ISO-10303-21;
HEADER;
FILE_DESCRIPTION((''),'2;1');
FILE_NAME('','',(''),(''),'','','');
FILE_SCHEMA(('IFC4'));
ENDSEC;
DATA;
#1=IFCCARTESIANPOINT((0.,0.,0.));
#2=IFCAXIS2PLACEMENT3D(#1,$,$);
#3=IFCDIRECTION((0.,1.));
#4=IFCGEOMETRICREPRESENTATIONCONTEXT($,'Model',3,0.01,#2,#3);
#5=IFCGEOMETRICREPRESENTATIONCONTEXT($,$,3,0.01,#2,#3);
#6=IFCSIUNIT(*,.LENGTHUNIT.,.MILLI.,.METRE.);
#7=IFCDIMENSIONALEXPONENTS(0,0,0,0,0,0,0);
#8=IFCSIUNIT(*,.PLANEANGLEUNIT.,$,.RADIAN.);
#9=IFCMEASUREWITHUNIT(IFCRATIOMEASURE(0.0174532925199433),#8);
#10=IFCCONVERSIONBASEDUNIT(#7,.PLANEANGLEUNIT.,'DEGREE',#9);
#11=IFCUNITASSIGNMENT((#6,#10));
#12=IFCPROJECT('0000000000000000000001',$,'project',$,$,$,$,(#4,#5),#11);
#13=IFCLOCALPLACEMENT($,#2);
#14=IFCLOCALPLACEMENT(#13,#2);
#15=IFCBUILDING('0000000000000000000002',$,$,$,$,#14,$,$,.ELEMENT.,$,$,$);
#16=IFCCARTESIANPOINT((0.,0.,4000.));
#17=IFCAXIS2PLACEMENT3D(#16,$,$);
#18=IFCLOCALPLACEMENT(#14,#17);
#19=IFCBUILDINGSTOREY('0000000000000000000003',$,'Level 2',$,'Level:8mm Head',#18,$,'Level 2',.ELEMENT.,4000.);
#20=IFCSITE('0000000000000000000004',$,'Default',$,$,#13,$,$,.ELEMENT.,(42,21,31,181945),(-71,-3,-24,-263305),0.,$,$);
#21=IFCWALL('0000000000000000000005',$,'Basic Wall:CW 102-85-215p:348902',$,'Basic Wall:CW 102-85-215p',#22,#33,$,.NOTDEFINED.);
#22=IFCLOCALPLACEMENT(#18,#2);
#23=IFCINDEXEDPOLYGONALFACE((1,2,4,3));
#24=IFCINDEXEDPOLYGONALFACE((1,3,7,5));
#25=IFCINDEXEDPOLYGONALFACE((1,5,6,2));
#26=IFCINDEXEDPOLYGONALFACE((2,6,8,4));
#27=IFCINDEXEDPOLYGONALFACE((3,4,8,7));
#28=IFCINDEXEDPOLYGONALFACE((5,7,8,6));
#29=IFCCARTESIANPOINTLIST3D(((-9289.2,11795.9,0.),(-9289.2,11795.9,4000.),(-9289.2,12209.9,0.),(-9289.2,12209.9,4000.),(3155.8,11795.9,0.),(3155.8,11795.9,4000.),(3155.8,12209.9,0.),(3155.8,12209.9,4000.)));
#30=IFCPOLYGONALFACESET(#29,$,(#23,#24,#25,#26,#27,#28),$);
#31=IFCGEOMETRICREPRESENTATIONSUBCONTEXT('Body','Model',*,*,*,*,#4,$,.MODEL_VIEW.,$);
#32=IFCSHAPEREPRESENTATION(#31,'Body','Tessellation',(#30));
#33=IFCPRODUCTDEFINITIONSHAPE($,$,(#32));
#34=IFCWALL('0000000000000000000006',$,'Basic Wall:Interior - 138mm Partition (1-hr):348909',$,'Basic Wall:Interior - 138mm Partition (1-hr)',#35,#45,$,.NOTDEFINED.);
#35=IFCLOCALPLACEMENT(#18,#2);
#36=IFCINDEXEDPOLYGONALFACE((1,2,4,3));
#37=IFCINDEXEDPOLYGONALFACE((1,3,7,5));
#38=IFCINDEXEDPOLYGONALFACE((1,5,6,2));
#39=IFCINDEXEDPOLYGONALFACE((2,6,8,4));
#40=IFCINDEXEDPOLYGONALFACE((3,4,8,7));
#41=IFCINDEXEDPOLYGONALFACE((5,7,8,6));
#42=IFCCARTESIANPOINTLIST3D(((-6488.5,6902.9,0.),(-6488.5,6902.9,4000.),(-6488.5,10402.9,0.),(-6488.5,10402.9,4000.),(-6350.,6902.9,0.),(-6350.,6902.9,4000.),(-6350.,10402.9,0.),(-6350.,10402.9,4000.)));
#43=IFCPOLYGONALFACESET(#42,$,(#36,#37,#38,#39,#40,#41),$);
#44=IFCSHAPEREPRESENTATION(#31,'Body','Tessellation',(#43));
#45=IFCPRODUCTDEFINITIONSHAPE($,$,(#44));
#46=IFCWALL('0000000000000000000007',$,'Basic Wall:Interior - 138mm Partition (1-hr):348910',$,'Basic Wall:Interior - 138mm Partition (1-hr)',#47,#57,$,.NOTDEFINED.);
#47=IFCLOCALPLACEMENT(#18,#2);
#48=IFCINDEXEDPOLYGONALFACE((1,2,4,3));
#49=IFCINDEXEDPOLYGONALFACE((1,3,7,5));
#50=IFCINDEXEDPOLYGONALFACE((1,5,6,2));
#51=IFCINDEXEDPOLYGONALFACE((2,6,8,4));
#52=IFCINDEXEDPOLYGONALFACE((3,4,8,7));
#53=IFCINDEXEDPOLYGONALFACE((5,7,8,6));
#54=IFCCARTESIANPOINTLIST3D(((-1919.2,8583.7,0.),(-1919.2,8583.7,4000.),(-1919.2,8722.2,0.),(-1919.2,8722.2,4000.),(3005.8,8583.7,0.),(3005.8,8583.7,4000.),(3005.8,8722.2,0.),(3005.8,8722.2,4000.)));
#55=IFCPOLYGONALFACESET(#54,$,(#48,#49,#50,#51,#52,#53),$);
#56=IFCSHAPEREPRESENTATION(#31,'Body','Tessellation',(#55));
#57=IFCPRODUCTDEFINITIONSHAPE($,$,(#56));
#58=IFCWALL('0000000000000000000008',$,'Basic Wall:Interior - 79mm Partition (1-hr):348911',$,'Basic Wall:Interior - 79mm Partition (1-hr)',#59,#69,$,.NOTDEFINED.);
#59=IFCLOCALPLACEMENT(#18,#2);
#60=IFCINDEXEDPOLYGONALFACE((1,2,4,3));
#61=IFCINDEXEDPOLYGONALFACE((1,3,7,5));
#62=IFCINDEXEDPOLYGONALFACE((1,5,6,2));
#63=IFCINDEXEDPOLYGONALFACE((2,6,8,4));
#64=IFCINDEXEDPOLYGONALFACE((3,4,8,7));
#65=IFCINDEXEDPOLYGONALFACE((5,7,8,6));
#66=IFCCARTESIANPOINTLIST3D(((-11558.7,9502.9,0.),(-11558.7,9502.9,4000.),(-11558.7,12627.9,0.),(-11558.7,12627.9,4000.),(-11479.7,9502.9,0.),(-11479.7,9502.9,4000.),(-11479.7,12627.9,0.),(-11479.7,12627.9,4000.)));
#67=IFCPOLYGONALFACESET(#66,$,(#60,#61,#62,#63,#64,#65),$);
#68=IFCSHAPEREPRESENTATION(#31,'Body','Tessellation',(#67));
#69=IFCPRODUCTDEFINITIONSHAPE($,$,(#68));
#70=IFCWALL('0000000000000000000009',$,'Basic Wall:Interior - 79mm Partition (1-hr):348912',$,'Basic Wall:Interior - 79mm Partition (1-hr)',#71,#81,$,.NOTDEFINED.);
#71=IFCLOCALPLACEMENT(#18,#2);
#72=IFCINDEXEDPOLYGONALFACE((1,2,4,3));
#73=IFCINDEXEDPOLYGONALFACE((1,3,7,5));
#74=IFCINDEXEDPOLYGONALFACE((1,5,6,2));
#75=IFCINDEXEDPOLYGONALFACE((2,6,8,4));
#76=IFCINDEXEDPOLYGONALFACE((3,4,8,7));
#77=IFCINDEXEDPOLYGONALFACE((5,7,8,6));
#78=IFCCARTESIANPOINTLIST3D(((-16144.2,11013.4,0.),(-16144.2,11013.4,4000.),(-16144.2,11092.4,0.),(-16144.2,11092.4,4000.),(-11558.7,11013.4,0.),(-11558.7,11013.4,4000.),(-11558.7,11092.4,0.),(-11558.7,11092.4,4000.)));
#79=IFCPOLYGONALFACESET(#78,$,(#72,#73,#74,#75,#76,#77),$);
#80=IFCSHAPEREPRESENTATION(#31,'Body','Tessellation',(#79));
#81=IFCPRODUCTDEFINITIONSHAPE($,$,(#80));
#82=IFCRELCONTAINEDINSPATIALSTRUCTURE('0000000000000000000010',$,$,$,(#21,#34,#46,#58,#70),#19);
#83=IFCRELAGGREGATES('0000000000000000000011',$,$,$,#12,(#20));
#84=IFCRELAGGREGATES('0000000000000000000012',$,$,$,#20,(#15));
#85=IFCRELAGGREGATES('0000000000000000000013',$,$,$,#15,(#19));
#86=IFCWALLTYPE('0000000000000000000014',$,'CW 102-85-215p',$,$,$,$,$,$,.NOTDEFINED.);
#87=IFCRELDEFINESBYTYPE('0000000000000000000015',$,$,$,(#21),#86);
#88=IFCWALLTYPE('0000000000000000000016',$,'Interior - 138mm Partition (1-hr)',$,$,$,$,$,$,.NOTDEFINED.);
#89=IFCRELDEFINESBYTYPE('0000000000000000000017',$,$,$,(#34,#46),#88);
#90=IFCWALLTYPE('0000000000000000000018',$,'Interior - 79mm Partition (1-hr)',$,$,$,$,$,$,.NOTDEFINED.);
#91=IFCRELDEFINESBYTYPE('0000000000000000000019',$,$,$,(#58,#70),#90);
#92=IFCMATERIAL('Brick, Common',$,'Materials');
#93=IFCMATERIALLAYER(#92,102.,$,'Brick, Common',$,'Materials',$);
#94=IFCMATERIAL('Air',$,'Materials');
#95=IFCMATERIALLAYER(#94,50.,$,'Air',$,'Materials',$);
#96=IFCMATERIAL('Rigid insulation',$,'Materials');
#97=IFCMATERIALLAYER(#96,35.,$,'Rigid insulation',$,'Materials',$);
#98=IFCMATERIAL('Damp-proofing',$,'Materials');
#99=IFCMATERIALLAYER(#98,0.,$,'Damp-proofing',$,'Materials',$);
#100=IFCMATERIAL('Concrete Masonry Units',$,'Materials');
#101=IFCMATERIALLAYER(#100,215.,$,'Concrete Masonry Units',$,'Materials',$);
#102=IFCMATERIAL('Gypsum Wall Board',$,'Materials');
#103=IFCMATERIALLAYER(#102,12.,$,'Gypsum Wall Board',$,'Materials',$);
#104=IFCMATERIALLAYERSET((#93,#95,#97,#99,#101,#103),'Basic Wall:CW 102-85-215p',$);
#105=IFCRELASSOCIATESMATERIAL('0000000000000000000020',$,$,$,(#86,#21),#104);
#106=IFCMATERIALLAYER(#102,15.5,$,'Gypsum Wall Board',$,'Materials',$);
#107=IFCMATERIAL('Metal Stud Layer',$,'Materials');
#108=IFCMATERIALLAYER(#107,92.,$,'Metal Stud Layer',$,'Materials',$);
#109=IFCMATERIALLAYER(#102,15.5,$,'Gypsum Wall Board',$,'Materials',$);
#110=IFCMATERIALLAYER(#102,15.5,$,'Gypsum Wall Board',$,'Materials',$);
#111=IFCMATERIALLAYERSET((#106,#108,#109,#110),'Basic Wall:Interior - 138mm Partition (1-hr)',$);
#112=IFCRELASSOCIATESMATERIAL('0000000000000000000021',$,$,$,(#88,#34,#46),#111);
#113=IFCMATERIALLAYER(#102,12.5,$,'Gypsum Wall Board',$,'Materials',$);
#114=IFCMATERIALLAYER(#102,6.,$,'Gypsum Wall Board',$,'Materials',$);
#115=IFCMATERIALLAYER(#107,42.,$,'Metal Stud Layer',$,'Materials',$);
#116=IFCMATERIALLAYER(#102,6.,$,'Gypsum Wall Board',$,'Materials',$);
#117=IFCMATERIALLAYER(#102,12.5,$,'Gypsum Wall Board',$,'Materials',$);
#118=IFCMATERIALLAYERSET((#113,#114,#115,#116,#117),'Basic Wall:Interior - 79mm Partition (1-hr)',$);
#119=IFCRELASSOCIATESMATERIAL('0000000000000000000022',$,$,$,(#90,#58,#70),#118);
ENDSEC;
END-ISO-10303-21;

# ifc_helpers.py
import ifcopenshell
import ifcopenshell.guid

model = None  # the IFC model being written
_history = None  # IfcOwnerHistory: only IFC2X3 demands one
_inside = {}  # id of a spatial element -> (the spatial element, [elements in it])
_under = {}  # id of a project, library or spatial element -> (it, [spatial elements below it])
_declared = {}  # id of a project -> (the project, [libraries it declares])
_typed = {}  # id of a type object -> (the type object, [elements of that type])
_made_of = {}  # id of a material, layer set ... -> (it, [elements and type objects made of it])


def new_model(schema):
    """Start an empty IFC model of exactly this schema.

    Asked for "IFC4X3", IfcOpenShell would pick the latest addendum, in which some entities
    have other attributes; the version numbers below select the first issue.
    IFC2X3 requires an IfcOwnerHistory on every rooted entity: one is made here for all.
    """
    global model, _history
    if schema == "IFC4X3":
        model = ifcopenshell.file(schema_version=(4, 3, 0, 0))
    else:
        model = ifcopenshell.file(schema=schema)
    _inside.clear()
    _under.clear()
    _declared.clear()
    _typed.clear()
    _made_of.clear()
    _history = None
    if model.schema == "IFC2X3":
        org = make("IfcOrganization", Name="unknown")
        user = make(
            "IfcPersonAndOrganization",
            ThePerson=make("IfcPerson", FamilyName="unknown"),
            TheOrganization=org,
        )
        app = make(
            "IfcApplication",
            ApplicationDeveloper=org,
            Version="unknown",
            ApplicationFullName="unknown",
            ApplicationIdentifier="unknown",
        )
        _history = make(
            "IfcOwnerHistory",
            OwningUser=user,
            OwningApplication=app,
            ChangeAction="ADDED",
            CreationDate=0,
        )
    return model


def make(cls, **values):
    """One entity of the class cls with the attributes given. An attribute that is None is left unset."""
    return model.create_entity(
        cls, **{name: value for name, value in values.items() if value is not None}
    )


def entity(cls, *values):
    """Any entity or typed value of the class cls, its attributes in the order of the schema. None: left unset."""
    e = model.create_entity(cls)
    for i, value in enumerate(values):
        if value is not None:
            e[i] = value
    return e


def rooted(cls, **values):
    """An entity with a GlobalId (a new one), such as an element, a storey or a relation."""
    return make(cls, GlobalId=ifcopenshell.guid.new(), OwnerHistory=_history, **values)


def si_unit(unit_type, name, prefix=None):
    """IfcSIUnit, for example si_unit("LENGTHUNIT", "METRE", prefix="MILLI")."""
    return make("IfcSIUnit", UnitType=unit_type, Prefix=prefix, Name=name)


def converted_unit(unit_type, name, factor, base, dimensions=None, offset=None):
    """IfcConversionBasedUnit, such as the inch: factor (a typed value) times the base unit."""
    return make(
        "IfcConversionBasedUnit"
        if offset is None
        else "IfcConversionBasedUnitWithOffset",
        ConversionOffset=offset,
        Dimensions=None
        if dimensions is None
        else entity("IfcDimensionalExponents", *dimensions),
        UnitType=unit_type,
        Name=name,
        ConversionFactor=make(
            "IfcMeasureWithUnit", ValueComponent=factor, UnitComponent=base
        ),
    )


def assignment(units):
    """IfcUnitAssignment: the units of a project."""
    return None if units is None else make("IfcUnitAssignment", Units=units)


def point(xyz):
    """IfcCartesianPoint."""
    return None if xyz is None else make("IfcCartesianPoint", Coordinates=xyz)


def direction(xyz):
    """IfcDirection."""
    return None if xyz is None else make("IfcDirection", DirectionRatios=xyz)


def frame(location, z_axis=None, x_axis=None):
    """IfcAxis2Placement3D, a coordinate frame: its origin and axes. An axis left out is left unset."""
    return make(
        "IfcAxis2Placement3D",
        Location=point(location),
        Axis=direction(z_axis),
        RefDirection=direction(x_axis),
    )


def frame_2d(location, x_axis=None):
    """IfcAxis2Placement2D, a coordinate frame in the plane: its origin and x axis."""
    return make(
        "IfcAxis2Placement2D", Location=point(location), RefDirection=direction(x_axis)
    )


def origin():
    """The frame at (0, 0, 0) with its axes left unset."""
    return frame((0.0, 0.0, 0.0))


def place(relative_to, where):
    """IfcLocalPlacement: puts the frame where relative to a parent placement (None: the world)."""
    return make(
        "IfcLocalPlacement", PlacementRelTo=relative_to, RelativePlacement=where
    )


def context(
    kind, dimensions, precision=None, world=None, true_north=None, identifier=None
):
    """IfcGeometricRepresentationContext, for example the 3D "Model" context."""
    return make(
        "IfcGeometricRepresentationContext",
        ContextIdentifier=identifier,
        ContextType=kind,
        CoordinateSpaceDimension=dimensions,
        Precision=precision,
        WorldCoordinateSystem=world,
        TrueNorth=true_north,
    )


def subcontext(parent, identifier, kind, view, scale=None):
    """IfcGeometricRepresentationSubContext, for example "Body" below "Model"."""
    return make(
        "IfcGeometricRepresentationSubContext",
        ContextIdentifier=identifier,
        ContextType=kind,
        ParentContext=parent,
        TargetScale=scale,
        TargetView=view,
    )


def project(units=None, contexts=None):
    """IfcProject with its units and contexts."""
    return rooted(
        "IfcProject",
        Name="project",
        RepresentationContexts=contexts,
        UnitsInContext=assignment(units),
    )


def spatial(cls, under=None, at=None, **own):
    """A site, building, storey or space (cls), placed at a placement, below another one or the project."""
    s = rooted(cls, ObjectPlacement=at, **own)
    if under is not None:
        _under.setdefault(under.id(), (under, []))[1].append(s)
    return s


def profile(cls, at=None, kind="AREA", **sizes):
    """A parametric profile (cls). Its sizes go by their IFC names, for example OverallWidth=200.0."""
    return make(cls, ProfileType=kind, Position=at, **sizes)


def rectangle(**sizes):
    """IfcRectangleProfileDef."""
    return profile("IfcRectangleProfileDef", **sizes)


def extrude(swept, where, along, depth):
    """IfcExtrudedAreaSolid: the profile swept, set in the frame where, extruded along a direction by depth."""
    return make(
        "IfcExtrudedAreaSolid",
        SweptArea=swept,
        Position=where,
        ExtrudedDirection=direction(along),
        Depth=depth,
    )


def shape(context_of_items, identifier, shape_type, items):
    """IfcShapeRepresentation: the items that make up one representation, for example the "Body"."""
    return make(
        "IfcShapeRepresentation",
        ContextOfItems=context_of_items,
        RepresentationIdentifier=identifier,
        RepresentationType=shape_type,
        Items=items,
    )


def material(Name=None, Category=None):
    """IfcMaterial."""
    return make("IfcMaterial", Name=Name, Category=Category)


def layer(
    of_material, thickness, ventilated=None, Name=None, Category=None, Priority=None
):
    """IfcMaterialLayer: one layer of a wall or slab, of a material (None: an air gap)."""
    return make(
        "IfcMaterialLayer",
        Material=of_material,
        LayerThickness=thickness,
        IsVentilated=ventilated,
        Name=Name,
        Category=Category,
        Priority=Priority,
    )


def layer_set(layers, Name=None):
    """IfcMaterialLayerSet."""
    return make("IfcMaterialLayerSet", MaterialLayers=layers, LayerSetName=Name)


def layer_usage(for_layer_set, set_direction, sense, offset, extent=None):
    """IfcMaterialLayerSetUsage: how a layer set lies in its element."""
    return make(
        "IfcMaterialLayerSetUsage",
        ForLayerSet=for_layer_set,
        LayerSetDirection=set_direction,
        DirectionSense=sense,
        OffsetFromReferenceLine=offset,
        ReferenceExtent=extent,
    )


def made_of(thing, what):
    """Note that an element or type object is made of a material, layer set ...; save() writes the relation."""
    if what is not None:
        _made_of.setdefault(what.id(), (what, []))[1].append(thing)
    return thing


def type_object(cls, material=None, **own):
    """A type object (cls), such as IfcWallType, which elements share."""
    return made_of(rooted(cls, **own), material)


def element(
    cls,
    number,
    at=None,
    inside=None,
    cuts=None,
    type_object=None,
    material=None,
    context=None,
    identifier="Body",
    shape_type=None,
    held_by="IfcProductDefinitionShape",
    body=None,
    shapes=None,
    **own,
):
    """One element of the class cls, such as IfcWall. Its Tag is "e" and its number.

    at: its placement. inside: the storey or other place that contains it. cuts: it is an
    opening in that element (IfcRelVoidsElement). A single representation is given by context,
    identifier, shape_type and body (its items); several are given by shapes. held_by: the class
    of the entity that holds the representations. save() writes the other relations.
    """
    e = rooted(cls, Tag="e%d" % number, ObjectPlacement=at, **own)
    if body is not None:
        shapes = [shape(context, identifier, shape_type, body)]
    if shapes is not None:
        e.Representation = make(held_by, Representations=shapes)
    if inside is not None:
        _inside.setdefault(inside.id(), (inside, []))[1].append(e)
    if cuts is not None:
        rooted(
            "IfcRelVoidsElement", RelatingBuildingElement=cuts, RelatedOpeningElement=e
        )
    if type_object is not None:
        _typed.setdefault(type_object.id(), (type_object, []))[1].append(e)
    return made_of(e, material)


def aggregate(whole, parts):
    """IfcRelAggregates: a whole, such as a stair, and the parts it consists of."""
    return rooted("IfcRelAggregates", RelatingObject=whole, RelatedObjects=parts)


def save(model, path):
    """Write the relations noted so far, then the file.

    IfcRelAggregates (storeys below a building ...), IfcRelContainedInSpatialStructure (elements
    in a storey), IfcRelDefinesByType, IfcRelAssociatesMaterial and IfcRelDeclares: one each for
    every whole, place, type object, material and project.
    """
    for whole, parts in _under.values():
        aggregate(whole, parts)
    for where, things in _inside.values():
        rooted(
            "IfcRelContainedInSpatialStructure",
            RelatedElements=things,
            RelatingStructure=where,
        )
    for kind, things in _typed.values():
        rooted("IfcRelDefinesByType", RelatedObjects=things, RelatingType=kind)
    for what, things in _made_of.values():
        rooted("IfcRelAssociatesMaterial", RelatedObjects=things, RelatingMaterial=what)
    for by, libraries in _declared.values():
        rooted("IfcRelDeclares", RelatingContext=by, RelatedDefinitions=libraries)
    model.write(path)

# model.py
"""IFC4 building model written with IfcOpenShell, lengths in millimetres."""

from ifc_helpers import new_model, entity, si_unit, converted_unit, direction, frame, frame_2d, origin, place, context, subcontext, project, spatial, rectangle, extrude, material, layer, layer_set, layer_usage, type_object, element, save


model = new_model("IFC4")

# Units and contexts
model_context = context("Model", 3, precision=0.01, world=origin(), true_north=direction((0.0, 1.0)))
context_of_model = context(None, 3, precision=0.01, world=origin(), true_north=direction((0.0, 1.0)))
body_context = subcontext(model_context, "Body", "Model", "MODEL_VIEW")
ifc_project = project(units=[si_unit("LENGTHUNIT", "METRE", prefix="MILLI"), converted_unit("PLANEANGLEUNIT", "DEGREE", entity("IfcRatioMeasure", 0.0174532925199433), si_unit("PLANEANGLEUNIT", "RADIAN"), dimensions=[0, 0, 0, 0, 0, 0, 0])], contexts=[model_context, context_of_model])

# Site, building, storey
site_placement = place(None, origin())
site = spatial("IfcSite", under=ifc_project, at=site_placement, Name="Default", CompositionType="ELEMENT", RefLatitude=(42, 21, 31, 181945), RefLongitude=(-71, -3, -24, -263305), RefElevation=0.0)
building_placement = place(site_placement, origin())
building = spatial("IfcBuilding", under=site, at=building_placement, CompositionType="ELEMENT")
storey_placement = place(building_placement, frame((0.0, 0.0, 4000.0)))
storey = spatial("IfcBuildingStorey", under=building, at=storey_placement, Name="Level 2", ObjectType="Level:8mm Head", LongName="Level 2", CompositionType="ELEMENT", Elevation=4000.0)

# Walls
ifc_material_1 = material(Name="Concrete Masonry Units", Category="Materials")
ifc_material_2 = material(Name="Brick, Common", Category="Materials")
ifc_layer_1 = layer(ifc_material_2, 102.0, Name="Brick, Common", Category="Materials")
ifc_material_3 = material(Name="Air", Category="Materials")
ifc_layer_2 = layer(ifc_material_3, 50.0, Name="Air", Category="Materials")
ifc_material_4 = material(Name="Rigid insulation", Category="Materials")
ifc_layer_3 = layer(ifc_material_4, 35.0, Name="Rigid insulation", Category="Materials")
ifc_material_5 = material(Name="Damp-proofing", Category="Materials")
ifc_layer_4 = layer(ifc_material_5, 0.0, Name="Damp-proofing", Category="Materials")
ifc_layer_5 = layer(ifc_material_1, 215.0, Name="Concrete Masonry Units", Category="Materials")
ifc_material_6 = material(Name="Gypsum Wall Board", Category="Materials")
ifc_layer_6 = layer(ifc_material_6, 12.0, Name="Gypsum Wall Board", Category="Materials")
ifc_layer_set_1 = layer_set([ifc_layer_1, ifc_layer_2, ifc_layer_3, ifc_layer_4, ifc_layer_5, ifc_layer_6], Name="Basic Wall:CW 102-85-215p")
ifc_layer_usage_1 = layer_usage(ifc_layer_set_1, "AXIS2", "NEGATIVE", 207.0)
wall_type_1 = type_object("IfcWallType", Name="CW 102-85-215p", PredefinedType="NOTDEFINED", material=ifc_layer_set_1)
wall_1_placement = place(storey_placement, frame((-9289.2, 12002.9, 0.0)))
element("IfcWall", 1, at=wall_1_placement, inside=storey, type_object=wall_type_1, material=ifc_layer_usage_1, Name="Basic Wall:CW 102-85-215p:348902", ObjectType="Basic Wall:CW 102-85-215p", PredefinedType="NOTDEFINED", context=body_context, shape_type="SweptSolid", body=[
    extrude(rectangle(XDim=12445.0, YDim=414.0, at=frame_2d((6222.5, 0.0), x_axis=(-1.0, 0.0))), origin(), (0.0, 0.0, 1.0), 4000.0),
])
ifc_layer_7 = layer(ifc_material_6, 15.5, Name="Gypsum Wall Board", Category="Materials")
ifc_material_7 = material(Name="Metal Stud Layer", Category="Materials")
ifc_layer_8 = layer(ifc_material_7, 92.0, Name="Metal Stud Layer", Category="Materials")
ifc_layer_9 = layer(ifc_material_6, 15.5, Name="Gypsum Wall Board", Category="Materials")
ifc_layer_10 = layer(ifc_material_6, 15.5, Name="Gypsum Wall Board", Category="Materials")
ifc_layer_set_2 = layer_set([ifc_layer_7, ifc_layer_8, ifc_layer_9, ifc_layer_10], Name="Basic Wall:Interior - 138mm Partition (1-hr)")
ifc_layer_usage_2 = layer_usage(ifc_layer_set_2, "AXIS2", "NEGATIVE", 69.2)
wall_type_2 = type_object("IfcWallType", Name="Interior - 138mm Partition (1-hr)", PredefinedType="NOTDEFINED", material=ifc_layer_set_2)
wall_2_placement = place(storey_placement, frame((-6419.2, 10402.9, 0.0), z_axis=(0.0, 0.0, 1.0), x_axis=(0.0, -1.0, 0.0)))
element("IfcWall", 2, at=wall_2_placement, inside=storey, type_object=wall_type_2, material=ifc_layer_usage_2, Name="Basic Wall:Interior - 138mm Partition (1-hr):348909", ObjectType="Basic Wall:Interior - 138mm Partition (1-hr)", PredefinedType="NOTDEFINED", context=body_context, shape_type="SweptSolid", body=[
    extrude(rectangle(XDim=3500.0, YDim=138.5, at=frame_2d((1750.0, 0.0), x_axis=(-1.0, 0.0))), origin(), (0.0, 0.0, 1.0), 4000.0),
])
ifc_layer_usage_3 = layer_usage(ifc_layer_set_2, "AXIS2", "NEGATIVE", 69.2)
wall_3_placement = place(storey_placement, frame((-1919.2, 8652.9, 0.0)))
element("IfcWall", 3, at=wall_3_placement, inside=storey, type_object=wall_type_2, material=ifc_layer_usage_3, Name="Basic Wall:Interior - 138mm Partition (1-hr):348910", ObjectType="Basic Wall:Interior - 138mm Partition (1-hr)", PredefinedType="NOTDEFINED", context=body_context, shape_type="SweptSolid", body=[
    extrude(rectangle(XDim=4925.0, YDim=138.5, at=frame_2d((2462.5, 0.0), x_axis=(-1.0, 0.0))), origin(), (0.0, 0.0, 1.0), 4000.0),
])
ifc_layer_11 = layer(ifc_material_6, 12.5, Name="Gypsum Wall Board", Category="Materials")
ifc_layer_12 = layer(ifc_material_6, 6.0, Name="Gypsum Wall Board", Category="Materials")
ifc_layer_13 = layer(ifc_material_7, 42.0, Name="Metal Stud Layer", Category="Materials")
ifc_layer_14 = layer(ifc_material_6, 6.0, Name="Gypsum Wall Board", Category="Materials")
ifc_layer_15 = layer(ifc_material_6, 12.5, Name="Gypsum Wall Board", Category="Materials")
ifc_layer_set_3 = layer_set([ifc_layer_11, ifc_layer_12, ifc_layer_13, ifc_layer_14, ifc_layer_15], Name="Basic Wall:Interior - 79mm Partition (1-hr)")
ifc_layer_usage_4 = layer_usage(ifc_layer_set_3, "AXIS2", "NEGATIVE", 39.5)
wall_type_3 = type_object("IfcWallType", Name="Interior - 79mm Partition (1-hr)", PredefinedType="NOTDEFINED", material=ifc_layer_set_3)
wall_4_placement = place(storey_placement, frame((-11519.2, 9502.9, 0.0), z_axis=(0.0, 0.0, 1.0), x_axis=(0.0, 1.0, 0.0)))
element("IfcWall", 4, at=wall_4_placement, inside=storey, type_object=wall_type_3, material=ifc_layer_usage_4, Name="Basic Wall:Interior - 79mm Partition (1-hr):348911", ObjectType="Basic Wall:Interior - 79mm Partition (1-hr)", PredefinedType="NOTDEFINED", context=body_context, shape_type="SweptSolid", body=[
    extrude(rectangle(XDim=3125.0, YDim=79.0, at=frame_2d((1562.5, 0.0), x_axis=(-1.0, 0.0))), origin(), (0.0, 0.0, 1.0), 4000.0),
])
ifc_layer_usage_5 = layer_usage(ifc_layer_set_3, "AXIS2", "NEGATIVE", 39.5)
wall_5_placement = place(storey_placement, frame((-16144.2, 11052.9, 0.0)))
element("IfcWall", 5, at=wall_5_placement, inside=storey, type_object=wall_type_3, material=ifc_layer_usage_5, Name="Basic Wall:Interior - 79mm Partition (1-hr):348912", ObjectType="Basic Wall:Interior - 79mm Partition (1-hr)", PredefinedType="NOTDEFINED", context=body_context, shape_type="SweptSolid", body=[
    extrude(rectangle(XDim=4585.5, YDim=79.0, at=frame_2d((2292.8, 0.0), x_axis=(-1.0, 0.0))), origin(), (0.0, 0.0, 1.0), 4000.0),
])

save(model, "model.ifc")
